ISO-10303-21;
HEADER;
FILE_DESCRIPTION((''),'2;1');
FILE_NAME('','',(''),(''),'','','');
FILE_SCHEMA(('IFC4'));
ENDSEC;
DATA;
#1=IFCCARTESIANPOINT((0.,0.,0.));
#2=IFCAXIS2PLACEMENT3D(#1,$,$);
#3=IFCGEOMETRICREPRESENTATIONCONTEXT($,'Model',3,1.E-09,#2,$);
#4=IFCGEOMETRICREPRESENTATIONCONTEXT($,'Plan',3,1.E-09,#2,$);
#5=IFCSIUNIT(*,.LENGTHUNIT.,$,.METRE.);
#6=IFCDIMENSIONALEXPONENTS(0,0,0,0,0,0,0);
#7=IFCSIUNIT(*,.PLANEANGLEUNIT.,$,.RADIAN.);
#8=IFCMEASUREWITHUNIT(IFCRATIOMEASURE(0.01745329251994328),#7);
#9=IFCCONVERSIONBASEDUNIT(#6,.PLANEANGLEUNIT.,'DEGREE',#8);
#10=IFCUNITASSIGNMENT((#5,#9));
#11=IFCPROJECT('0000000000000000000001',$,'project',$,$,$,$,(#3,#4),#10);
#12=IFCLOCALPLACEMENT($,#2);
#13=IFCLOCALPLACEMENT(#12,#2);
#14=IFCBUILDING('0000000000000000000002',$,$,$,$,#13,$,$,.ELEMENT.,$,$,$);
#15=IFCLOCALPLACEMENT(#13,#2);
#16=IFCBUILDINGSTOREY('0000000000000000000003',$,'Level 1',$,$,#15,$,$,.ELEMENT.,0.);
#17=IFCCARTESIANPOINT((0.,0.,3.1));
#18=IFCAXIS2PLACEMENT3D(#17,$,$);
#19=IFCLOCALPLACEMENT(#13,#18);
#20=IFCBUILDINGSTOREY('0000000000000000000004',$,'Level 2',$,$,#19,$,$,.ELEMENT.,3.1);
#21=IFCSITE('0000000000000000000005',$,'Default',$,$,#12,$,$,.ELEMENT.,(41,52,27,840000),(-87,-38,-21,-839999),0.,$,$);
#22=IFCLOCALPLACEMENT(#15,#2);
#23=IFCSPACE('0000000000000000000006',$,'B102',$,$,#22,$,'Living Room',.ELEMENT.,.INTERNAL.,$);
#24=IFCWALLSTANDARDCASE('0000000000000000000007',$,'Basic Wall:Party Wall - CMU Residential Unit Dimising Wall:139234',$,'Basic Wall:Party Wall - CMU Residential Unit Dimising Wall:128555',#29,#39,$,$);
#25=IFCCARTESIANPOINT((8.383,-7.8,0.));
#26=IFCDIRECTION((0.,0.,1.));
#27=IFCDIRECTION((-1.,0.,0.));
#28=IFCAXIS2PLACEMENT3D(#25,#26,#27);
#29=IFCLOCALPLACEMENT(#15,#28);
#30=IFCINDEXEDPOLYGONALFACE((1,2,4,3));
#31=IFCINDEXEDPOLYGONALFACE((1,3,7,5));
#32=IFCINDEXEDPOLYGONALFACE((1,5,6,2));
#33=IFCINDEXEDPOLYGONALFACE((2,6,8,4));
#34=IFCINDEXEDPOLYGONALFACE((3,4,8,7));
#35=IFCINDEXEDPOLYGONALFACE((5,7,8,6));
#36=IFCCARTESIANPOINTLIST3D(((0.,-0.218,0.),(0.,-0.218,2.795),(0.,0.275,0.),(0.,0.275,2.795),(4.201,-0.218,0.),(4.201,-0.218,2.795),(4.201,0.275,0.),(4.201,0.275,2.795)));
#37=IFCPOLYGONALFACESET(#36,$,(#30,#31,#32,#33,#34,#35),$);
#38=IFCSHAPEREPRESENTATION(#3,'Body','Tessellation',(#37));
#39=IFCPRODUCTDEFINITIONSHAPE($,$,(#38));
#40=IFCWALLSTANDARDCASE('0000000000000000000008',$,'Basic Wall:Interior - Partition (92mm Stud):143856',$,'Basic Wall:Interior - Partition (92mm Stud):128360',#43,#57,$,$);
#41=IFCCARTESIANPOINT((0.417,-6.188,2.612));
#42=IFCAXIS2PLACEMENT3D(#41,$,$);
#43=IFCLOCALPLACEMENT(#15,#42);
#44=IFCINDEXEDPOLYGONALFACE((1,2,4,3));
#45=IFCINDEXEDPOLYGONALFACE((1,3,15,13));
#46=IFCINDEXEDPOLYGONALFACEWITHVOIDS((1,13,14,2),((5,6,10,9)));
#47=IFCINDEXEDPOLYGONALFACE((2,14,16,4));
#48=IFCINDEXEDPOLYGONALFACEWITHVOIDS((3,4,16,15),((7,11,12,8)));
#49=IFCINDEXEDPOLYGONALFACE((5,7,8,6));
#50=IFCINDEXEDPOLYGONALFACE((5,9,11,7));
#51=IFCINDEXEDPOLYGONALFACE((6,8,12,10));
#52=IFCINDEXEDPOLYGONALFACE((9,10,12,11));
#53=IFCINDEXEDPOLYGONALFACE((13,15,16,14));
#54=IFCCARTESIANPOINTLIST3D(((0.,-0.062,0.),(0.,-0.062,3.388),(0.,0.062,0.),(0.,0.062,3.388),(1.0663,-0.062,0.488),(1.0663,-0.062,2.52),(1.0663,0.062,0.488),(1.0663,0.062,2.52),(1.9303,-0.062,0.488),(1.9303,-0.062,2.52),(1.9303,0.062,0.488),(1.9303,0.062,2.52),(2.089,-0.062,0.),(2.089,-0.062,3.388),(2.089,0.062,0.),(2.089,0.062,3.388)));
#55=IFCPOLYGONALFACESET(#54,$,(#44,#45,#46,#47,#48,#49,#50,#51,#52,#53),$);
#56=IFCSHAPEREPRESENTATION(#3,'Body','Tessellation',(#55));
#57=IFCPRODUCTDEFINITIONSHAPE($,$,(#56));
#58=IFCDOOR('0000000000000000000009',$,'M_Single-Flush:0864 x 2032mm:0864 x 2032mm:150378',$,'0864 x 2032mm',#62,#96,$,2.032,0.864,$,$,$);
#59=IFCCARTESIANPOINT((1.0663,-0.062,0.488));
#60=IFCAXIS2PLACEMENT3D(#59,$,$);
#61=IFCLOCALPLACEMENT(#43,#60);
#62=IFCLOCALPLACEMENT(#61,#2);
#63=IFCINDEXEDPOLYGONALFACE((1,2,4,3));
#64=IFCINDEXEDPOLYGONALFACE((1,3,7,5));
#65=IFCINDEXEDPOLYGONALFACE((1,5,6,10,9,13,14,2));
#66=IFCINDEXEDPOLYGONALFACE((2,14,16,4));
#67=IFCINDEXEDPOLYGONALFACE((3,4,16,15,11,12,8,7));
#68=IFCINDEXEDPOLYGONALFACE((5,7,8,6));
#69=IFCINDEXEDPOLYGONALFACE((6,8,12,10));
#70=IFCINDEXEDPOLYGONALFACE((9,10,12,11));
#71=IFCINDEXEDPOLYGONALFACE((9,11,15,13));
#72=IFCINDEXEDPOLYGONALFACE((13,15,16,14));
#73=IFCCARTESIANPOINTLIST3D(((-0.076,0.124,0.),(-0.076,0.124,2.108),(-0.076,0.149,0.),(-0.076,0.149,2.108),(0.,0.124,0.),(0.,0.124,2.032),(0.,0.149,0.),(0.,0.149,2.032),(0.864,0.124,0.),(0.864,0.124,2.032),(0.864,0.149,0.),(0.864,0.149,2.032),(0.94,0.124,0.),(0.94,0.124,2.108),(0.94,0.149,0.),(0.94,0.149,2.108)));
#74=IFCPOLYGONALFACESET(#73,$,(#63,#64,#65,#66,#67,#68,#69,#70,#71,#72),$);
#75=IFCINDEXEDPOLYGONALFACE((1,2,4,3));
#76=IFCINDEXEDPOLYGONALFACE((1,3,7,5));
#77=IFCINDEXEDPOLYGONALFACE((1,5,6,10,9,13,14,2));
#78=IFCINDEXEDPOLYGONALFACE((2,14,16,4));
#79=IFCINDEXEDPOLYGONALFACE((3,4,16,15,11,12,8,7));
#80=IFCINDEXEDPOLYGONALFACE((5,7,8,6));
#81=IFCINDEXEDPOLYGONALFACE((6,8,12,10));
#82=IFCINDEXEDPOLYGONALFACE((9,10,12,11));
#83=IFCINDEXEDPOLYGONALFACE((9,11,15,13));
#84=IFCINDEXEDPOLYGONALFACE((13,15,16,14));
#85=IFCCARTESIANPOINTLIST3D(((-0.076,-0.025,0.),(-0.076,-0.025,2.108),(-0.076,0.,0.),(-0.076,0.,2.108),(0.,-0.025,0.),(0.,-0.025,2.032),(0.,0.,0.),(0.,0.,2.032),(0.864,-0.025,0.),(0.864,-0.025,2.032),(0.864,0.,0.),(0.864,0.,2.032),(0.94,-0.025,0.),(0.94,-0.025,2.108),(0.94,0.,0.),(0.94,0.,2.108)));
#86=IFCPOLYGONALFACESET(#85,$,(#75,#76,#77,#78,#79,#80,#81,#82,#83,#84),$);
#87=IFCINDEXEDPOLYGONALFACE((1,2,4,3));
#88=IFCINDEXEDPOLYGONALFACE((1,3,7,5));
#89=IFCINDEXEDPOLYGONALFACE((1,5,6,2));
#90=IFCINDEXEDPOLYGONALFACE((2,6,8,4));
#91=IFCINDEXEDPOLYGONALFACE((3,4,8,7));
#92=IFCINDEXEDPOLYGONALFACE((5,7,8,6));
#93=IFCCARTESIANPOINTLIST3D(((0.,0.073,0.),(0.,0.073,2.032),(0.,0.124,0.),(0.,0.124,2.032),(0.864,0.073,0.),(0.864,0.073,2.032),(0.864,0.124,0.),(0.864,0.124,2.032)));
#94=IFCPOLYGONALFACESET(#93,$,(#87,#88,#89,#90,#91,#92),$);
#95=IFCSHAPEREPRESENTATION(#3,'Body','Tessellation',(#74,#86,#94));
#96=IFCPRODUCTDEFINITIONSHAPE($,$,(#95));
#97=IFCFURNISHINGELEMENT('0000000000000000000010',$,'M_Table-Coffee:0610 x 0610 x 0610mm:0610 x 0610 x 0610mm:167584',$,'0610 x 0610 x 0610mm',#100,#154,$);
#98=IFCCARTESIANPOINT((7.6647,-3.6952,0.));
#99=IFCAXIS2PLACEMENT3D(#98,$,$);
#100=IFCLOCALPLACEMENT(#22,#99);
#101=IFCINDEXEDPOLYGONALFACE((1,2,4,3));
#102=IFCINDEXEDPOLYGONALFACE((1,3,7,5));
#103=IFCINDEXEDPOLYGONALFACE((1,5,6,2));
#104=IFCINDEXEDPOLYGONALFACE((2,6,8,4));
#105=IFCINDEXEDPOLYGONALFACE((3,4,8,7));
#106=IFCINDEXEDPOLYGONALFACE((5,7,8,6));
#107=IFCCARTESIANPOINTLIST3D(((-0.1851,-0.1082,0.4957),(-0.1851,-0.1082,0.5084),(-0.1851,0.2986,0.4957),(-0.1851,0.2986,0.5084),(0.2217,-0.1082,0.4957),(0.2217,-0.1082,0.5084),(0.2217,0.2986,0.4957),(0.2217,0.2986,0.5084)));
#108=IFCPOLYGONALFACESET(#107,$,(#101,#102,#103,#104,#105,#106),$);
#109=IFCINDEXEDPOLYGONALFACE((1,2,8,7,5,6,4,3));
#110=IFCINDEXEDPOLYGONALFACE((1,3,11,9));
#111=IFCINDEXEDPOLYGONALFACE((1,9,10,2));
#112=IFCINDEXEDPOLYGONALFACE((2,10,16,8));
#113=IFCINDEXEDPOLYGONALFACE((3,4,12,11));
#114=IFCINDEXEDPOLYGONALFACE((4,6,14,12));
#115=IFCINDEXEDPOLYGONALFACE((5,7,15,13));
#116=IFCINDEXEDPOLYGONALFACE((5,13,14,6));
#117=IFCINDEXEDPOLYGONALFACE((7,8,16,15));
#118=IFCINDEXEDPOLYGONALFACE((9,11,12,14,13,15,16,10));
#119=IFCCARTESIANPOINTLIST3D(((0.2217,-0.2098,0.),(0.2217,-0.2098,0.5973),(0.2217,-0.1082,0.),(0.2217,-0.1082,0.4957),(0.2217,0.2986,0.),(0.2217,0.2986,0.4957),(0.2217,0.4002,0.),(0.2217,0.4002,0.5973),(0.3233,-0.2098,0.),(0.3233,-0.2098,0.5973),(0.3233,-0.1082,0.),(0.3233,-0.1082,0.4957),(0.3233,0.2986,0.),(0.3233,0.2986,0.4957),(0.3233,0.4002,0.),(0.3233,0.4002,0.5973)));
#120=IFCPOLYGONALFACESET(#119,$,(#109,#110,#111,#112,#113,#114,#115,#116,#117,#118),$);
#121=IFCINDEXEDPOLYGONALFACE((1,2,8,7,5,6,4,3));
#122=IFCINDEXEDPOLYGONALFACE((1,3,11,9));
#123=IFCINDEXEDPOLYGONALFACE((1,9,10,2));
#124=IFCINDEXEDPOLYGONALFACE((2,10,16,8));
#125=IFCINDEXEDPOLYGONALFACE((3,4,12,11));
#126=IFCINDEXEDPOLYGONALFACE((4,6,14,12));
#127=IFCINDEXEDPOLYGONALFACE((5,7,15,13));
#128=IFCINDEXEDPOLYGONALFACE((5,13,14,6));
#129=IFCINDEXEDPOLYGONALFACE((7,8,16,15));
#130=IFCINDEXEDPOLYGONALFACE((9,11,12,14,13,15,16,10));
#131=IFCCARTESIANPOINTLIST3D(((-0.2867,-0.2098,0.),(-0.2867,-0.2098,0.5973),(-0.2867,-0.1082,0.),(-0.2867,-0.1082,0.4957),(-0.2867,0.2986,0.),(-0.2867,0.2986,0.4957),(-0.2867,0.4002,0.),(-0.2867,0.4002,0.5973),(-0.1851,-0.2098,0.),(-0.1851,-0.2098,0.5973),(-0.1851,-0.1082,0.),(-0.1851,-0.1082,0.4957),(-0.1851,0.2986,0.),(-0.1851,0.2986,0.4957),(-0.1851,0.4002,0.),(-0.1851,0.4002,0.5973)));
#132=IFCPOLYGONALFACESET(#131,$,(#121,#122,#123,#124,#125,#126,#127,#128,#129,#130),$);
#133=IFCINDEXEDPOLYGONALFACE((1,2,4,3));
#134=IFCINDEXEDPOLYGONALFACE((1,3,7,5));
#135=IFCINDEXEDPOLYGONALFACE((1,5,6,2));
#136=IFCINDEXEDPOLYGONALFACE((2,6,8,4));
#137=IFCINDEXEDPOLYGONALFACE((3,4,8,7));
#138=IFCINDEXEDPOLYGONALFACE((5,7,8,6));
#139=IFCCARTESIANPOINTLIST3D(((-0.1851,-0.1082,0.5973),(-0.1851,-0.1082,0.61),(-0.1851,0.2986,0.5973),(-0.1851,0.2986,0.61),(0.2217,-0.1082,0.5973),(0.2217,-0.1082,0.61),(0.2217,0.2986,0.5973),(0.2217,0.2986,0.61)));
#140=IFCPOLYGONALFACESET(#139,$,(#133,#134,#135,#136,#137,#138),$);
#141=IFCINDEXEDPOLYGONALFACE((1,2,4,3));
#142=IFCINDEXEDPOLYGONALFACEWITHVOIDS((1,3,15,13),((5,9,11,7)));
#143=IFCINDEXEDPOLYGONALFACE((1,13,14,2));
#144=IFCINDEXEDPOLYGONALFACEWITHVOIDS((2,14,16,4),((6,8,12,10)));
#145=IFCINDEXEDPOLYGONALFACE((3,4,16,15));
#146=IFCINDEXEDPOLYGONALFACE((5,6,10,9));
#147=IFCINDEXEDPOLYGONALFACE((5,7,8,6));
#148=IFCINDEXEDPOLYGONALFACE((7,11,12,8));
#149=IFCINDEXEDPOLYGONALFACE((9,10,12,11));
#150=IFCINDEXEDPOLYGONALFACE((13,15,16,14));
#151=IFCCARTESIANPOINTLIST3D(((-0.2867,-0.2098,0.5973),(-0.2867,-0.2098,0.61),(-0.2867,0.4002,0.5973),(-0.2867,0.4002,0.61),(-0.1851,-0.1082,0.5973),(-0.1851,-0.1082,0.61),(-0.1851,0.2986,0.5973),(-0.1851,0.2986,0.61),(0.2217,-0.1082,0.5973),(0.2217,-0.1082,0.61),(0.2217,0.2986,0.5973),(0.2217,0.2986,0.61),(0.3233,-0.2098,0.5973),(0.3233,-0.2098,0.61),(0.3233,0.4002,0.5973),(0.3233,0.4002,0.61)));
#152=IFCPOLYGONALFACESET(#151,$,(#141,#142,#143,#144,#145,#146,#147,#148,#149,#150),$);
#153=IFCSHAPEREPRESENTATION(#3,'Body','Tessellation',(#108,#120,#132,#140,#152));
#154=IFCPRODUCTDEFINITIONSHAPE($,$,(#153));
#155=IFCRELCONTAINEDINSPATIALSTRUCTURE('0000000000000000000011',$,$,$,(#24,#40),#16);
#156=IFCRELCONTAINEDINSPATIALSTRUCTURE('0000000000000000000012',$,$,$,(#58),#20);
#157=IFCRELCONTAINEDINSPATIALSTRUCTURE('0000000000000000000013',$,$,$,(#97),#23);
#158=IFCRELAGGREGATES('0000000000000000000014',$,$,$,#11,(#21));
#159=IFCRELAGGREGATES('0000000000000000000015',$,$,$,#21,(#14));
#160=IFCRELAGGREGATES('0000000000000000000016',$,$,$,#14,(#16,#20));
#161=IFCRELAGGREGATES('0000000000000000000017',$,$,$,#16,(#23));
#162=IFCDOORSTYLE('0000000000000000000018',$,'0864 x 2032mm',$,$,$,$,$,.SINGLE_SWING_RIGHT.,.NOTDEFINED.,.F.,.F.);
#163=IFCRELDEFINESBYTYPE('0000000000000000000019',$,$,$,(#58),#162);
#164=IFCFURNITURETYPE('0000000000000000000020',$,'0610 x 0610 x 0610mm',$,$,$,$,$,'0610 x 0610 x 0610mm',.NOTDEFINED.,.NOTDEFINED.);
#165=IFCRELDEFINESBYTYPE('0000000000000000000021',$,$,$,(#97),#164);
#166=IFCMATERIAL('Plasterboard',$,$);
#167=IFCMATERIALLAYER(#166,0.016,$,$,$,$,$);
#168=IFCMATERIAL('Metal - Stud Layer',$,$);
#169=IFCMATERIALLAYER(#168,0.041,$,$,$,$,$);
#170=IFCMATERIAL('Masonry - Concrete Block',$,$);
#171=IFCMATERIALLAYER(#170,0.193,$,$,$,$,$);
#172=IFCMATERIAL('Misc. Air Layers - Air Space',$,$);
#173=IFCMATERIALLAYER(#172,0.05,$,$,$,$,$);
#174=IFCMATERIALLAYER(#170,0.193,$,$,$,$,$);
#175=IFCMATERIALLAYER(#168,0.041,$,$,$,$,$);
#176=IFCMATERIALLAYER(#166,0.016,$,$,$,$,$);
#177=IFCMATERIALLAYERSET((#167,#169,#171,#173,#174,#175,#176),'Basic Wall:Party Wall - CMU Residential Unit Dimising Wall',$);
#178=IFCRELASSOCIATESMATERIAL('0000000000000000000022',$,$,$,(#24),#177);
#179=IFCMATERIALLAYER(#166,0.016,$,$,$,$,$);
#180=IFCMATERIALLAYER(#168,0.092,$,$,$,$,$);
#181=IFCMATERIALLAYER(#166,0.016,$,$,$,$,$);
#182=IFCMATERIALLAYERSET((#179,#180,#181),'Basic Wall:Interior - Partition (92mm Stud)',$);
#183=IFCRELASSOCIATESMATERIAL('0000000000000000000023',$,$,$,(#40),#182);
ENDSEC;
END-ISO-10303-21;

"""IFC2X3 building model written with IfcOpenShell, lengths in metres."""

from ifc_helpers import new_model, entity, si_unit, converted_unit, frame, frame_2d, origin, origin_2d_with_axis, place, context, project, spatial, polyline, rectangle, outline, extrude, clip, bounded_halfspace, source, transform, mapped, material, layer, layer_set, layer_usage, type_object, type_shapes, element, fill, save


model = new_model("IFC2X3")

# Units and contexts
model_context = context("Model", 3, precision=1e-09, world=origin())
plan_context = context("Plan", 3, precision=1e-09, world=origin())
ifc_project = project(units=[si_unit("LENGTHUNIT", "METRE"), converted_unit("PLANEANGLEUNIT", "DEGREE", entity("IfcRatioMeasure", 0.01745329251994328), si_unit("PLANEANGLEUNIT", "RADIAN"), dimensions=[0, 0, 0, 0, 0, 0, 0])], contexts=[model_context, plan_context])

# Site, building, storey
site_placement = place(None, origin())
site = spatial("IfcSite", under=ifc_project, at=site_placement, Name="Default", CompositionType="ELEMENT", RefLatitude=(41, 52, 27, 840000), RefLongitude=(-87, -38, -21, -839999), RefElevation=0.0)
building_placement = place(site_placement, origin())
building = spatial("IfcBuilding", under=site, at=building_placement, CompositionType="ELEMENT")
storey_1_placement = place(building_placement, origin())
storey_1 = spatial("IfcBuildingStorey", under=building, at=storey_1_placement, Name="Level 1", CompositionType="ELEMENT", Elevation=0.0)

# Shared definitions
ifc_material_1 = material(Name="Misc. Air Layers - Air Space")
ifc_material_2 = material(Name="Masonry - Concrete Block")
ifc_material_3 = material(Name="Metal - Stud Layer")
ifc_material_4 = material(Name="Plasterboard")

# Shared definitions
ifc_layer_1 = layer(ifc_material_4, 0.016)
ifc_layer_2 = layer(ifc_material_3, 0.092)
ifc_layer_3 = layer(ifc_material_4, 0.016)
ifc_layer_set_1 = layer_set([ifc_layer_1, ifc_layer_2, ifc_layer_3], Name="Basic Wall:Interior - Partition (92mm Stud)")

# Wall
ifc_layer_4 = layer(ifc_material_4, 0.016)
ifc_layer_5 = layer(ifc_material_3, 0.041)
ifc_layer_6 = layer(ifc_material_2, 0.193)
ifc_layer_7 = layer(ifc_material_1, 0.05)
ifc_layer_8 = layer(ifc_material_2, 0.193)
ifc_layer_9 = layer(ifc_material_3, 0.041)
ifc_layer_10 = layer(ifc_material_4, 0.016)
ifc_layer_set_2 = layer_set([ifc_layer_4, ifc_layer_5, ifc_layer_6, ifc_layer_7, ifc_layer_8, ifc_layer_9, ifc_layer_10], Name="Basic Wall:Party Wall - CMU Residential Unit Dimising Wall")
ifc_layer_usage_1 = layer_usage(ifc_layer_set_2, "AXIS2", "NEGATIVE", 0.275)
wall_1_placement = place(storey_1_placement, frame((8.383, -7.8, 0.0), z_axis=(0.0, 0.0, 1.0), x_axis=(-1.0, 0.0, 0.0)))
element("IfcWallStandardCase", 1, at=wall_1_placement, inside=storey_1, material=ifc_layer_usage_1, Name="Basic Wall:Party Wall - CMU Residential Unit Dimising Wall:139234", ObjectType="Basic Wall:Party Wall - CMU Residential Unit Dimising Wall:128555", context=model_context, shape_type="Clipping", body=[
    clip(clip(extrude(rectangle(XDim=4.201, YDim=0.55, at=frame_2d((2.1005, 0.0), x_axis=(-1.0, 0.0))), origin(), (0.0, 0.0, 1.0), 2.795), bounded_halfspace(frame((0.0, -0.218, 2.795), z_axis=(0.0, 1.0, 0.0), x_axis=(-1.0, 0.0, 0.0)), True, frame((0.0, -0.218, 2.795), z_axis=(0.0, 1.0, 0.0), x_axis=(-1.0, 0.0, 0.0)), polyline([(0.0, 0.0), (-3.708, 0.0), (-4.201, 0.0), (-4.201, -2.795), (0.0, -2.795), (0.0, 0.0)]))), bounded_halfspace(frame((4.201, 0.275, 0.0), z_axis=(-1.0, 0.0, 0.0), x_axis=(0.0, -1.0, 0.0)), True, frame((4.201, 0.275, 0.0), z_axis=(-1.0, 0.0, 0.0), x_axis=(0.0, -1.0, 0.0)), polyline([(0.0, 0.0), (0.493, 0.0), (0.493, 2.795), (0.0, 2.795), (0.0, 0.0)]))),
])

# Wall, opening
ifc_layer_usage_2 = layer_usage(ifc_layer_set_1, "AXIS2", "NEGATIVE", 0.062)
wall_2_placement = place(storey_1_placement, frame((0.417, -6.188, 2.612)))
wall_2 = element("IfcWallStandardCase", 2, at=wall_2_placement, inside=storey_1, material=ifc_layer_usage_2, Name="Basic Wall:Interior - Partition (92mm Stud):143856", ObjectType="Basic Wall:Interior - Partition (92mm Stud):128360", context=model_context, shape_type="SweptSolid", body=[
    extrude(rectangle(XDim=2.089, YDim=0.124, at=frame_2d((1.0445, 0.0), x_axis=(-1.0, 0.0))), origin(), (0.0, 0.0, 1.0), 3.388),
])
opening_1_placement = place(wall_2_placement, frame((1.0663, -0.062, 0.488)))
opening_1 = element("IfcOpeningElement", 3, at=opening_1_placement, cuts=wall_2, ObjectType="Opening", context=model_context, shape_type="SweptSolid", body=[
    extrude(rectangle(XDim=0.864, YDim=2.032, at=frame_2d((1.016, 0.432), x_axis=(0.0, 1.0))), frame((0.0, 0.0, 0.0), z_axis=(0.0, 1.0, 0.0), x_axis=(0.0, 0.0, 1.0)), (0.0, 0.0, 1.0), 0.124),
])

# Shared definitions
storey_2_placement = place(building_placement, frame((0.0, 0.0, 3.1)))
storey_2 = spatial("IfcBuildingStorey", under=building, at=storey_2_placement, Name="Level 2", CompositionType="ELEMENT", Elevation=3.1)

# Door
door_style_1 = type_object("IfcDoorStyle", Name="0864 x 2032mm", ConstructionType="NOTDEFINED", OperationType="SINGLE_SWING_RIGHT", ParameterTakesPrecedence=False, Sizeable=False)
shared_shape_1 = source(origin(), model_context, "Body", "SweptSolid", [
    extrude(outline(polyline([(-0.508, -1.073), (0.508, -1.073), (0.508, 1.035), (0.432, 1.035), (0.432, -0.997), (-0.432, -0.997), (-0.432, 1.035), (-0.508, 1.035), (-0.508, -1.073)])), frame((0.432, 0.124, 1.035), z_axis=(0.0, 1.0, 0.0), x_axis=(1.0, 0.0, 0.0)), (0.0, 0.0, 1.0), 0.025),
    extrude(outline(polyline([(-1.073, -0.508), (1.035, -0.508), (1.035, -0.432), (-0.997, -0.432), (-0.997, 0.432), (1.035, 0.432), (1.035, 0.508), (-1.073, 0.508), (-1.073, -0.508)])), frame((0.432, -0.025, 1.035), z_axis=(0.0, 1.0, 0.0), x_axis=(0.0, 0.0, -1.0)), (0.0, 0.0, 1.0), 0.025),
    extrude(rectangle(XDim=0.051, YDim=0.864, at=origin_2d_with_axis()), frame((0.432, 0.0985, 0.0), z_axis=(0.0, 0.0, 1.0), x_axis=(0.0, 1.0, 0.0)), (0.0, 0.0, 1.0), 2.032),
])
type_shapes(door_style_1, [shared_shape_1])
door_1_placement = place(opening_1_placement, origin())
door_1 = element("IfcDoor", 4, at=door_1_placement, inside=storey_2, type_object=door_style_1, Name="M_Single-Flush:0864 x 2032mm:0864 x 2032mm:150378", ObjectType="0864 x 2032mm", OverallHeight=2.032, OverallWidth=0.864, context=model_context, shape_type="MappedRepresentation", body=[
    mapped(shared_shape_1, transform((0.0, 0.0, 0.0), scale=1.0)),
])
fill(opening_1, door_1)

# Shared definitions
space_1_placement = place(storey_1_placement, origin())
space_1 = spatial("IfcSpace", under=storey_1, at=space_1_placement, Name="B102", LongName="Living Room", CompositionType="ELEMENT", InteriorOrExteriorSpace="INTERNAL")

# Furnishing element
furniture_type_1 = type_object("IfcFurnitureType", Name="0610 x 0610 x 0610mm", ElementType="0610 x 0610 x 0610mm", AssemblyPlace="NOTDEFINED")
shared_shape_2 = source(origin(), model_context, "Body", "SweptSolid", [
    extrude(rectangle(XDim=0.4068, YDim=0.4068, at=origin_2d_with_axis()), frame((0.0183, 0.0952, 0.4957), z_axis=(0.0, 0.0, 1.0), x_axis=(-1.0, 0.0, 0.0)), (0.0, 0.0, 1.0), 0.0127),
    extrude(outline(polyline([(-0.2732, -0.305), (0.324, -0.305), (0.324, 0.305), (-0.2732, 0.305), (-0.2732, 0.2034), (0.2225, 0.2034), (0.2225, -0.2034), (-0.2732, -0.2034), (-0.2732, -0.305)])), frame((0.2217, 0.0952, 0.2732), z_axis=(1.0, 0.0, 0.0), x_axis=(0.0, 0.0, 1.0)), (0.0, 0.0, 1.0), 0.1016),
    extrude(outline(polyline([(-0.305, -0.3241), (0.305, -0.3241), (0.305, 0.2733), (0.2034, 0.2733), (0.2034, -0.2224), (-0.2034, -0.2224), (-0.2034, 0.2733), (-0.305, 0.2733), (-0.305, -0.3241)])), frame((-0.2867, 0.0952, 0.2733), z_axis=(1.0, 0.0, 0.0), x_axis=(0.0, -1.0, 0.0)), (0.0, 0.0, 1.0), 0.1016),
    extrude(rectangle(XDim=0.4068, YDim=0.4068, at=origin_2d_with_axis()), frame((0.0183, 0.0952, 0.5973), z_axis=(0.0, 0.0, 1.0), x_axis=(-1.0, 0.0, 0.0)), (0.0, 0.0, 1.0), 0.0127),
    extrude(outline(polyline([(-0.305, -0.305), (0.305, -0.305), (0.305, 0.305), (-0.305, 0.305), (-0.305, -0.305)]), holes=[polyline([(-0.2034, -0.2034), (-0.2034, 0.2034), (0.2034, 0.2034), (0.2034, -0.2034), (-0.2034, -0.2034)])]), frame((0.0183, 0.0952, 0.5973), z_axis=(0.0, 0.0, 1.0), x_axis=(-1.0, 0.0, 0.0)), (0.0, 0.0, 1.0), 0.0127),
])
type_shapes(furniture_type_1, [shared_shape_2])
for number, where, name in (
    (5, (7.6647, -3.6952, 0.0), "M_Table-Coffee:0610 x 0610 x 0610mm:0610 x 0610 x 0610mm:167584"),
):
    element("IfcFurnishingElement", number, at=place(space_1_placement, frame(where)), inside=space_1, type_object=furniture_type_1, Name=name, ObjectType="0610 x 0610 x 0610mm", context=model_context, shape_type="MappedRepresentation", body=[
        mapped(shared_shape_2, transform((0.0, 0.0, 0.0), scale=1.0)),
    ])

save(model, "model.ifc")
